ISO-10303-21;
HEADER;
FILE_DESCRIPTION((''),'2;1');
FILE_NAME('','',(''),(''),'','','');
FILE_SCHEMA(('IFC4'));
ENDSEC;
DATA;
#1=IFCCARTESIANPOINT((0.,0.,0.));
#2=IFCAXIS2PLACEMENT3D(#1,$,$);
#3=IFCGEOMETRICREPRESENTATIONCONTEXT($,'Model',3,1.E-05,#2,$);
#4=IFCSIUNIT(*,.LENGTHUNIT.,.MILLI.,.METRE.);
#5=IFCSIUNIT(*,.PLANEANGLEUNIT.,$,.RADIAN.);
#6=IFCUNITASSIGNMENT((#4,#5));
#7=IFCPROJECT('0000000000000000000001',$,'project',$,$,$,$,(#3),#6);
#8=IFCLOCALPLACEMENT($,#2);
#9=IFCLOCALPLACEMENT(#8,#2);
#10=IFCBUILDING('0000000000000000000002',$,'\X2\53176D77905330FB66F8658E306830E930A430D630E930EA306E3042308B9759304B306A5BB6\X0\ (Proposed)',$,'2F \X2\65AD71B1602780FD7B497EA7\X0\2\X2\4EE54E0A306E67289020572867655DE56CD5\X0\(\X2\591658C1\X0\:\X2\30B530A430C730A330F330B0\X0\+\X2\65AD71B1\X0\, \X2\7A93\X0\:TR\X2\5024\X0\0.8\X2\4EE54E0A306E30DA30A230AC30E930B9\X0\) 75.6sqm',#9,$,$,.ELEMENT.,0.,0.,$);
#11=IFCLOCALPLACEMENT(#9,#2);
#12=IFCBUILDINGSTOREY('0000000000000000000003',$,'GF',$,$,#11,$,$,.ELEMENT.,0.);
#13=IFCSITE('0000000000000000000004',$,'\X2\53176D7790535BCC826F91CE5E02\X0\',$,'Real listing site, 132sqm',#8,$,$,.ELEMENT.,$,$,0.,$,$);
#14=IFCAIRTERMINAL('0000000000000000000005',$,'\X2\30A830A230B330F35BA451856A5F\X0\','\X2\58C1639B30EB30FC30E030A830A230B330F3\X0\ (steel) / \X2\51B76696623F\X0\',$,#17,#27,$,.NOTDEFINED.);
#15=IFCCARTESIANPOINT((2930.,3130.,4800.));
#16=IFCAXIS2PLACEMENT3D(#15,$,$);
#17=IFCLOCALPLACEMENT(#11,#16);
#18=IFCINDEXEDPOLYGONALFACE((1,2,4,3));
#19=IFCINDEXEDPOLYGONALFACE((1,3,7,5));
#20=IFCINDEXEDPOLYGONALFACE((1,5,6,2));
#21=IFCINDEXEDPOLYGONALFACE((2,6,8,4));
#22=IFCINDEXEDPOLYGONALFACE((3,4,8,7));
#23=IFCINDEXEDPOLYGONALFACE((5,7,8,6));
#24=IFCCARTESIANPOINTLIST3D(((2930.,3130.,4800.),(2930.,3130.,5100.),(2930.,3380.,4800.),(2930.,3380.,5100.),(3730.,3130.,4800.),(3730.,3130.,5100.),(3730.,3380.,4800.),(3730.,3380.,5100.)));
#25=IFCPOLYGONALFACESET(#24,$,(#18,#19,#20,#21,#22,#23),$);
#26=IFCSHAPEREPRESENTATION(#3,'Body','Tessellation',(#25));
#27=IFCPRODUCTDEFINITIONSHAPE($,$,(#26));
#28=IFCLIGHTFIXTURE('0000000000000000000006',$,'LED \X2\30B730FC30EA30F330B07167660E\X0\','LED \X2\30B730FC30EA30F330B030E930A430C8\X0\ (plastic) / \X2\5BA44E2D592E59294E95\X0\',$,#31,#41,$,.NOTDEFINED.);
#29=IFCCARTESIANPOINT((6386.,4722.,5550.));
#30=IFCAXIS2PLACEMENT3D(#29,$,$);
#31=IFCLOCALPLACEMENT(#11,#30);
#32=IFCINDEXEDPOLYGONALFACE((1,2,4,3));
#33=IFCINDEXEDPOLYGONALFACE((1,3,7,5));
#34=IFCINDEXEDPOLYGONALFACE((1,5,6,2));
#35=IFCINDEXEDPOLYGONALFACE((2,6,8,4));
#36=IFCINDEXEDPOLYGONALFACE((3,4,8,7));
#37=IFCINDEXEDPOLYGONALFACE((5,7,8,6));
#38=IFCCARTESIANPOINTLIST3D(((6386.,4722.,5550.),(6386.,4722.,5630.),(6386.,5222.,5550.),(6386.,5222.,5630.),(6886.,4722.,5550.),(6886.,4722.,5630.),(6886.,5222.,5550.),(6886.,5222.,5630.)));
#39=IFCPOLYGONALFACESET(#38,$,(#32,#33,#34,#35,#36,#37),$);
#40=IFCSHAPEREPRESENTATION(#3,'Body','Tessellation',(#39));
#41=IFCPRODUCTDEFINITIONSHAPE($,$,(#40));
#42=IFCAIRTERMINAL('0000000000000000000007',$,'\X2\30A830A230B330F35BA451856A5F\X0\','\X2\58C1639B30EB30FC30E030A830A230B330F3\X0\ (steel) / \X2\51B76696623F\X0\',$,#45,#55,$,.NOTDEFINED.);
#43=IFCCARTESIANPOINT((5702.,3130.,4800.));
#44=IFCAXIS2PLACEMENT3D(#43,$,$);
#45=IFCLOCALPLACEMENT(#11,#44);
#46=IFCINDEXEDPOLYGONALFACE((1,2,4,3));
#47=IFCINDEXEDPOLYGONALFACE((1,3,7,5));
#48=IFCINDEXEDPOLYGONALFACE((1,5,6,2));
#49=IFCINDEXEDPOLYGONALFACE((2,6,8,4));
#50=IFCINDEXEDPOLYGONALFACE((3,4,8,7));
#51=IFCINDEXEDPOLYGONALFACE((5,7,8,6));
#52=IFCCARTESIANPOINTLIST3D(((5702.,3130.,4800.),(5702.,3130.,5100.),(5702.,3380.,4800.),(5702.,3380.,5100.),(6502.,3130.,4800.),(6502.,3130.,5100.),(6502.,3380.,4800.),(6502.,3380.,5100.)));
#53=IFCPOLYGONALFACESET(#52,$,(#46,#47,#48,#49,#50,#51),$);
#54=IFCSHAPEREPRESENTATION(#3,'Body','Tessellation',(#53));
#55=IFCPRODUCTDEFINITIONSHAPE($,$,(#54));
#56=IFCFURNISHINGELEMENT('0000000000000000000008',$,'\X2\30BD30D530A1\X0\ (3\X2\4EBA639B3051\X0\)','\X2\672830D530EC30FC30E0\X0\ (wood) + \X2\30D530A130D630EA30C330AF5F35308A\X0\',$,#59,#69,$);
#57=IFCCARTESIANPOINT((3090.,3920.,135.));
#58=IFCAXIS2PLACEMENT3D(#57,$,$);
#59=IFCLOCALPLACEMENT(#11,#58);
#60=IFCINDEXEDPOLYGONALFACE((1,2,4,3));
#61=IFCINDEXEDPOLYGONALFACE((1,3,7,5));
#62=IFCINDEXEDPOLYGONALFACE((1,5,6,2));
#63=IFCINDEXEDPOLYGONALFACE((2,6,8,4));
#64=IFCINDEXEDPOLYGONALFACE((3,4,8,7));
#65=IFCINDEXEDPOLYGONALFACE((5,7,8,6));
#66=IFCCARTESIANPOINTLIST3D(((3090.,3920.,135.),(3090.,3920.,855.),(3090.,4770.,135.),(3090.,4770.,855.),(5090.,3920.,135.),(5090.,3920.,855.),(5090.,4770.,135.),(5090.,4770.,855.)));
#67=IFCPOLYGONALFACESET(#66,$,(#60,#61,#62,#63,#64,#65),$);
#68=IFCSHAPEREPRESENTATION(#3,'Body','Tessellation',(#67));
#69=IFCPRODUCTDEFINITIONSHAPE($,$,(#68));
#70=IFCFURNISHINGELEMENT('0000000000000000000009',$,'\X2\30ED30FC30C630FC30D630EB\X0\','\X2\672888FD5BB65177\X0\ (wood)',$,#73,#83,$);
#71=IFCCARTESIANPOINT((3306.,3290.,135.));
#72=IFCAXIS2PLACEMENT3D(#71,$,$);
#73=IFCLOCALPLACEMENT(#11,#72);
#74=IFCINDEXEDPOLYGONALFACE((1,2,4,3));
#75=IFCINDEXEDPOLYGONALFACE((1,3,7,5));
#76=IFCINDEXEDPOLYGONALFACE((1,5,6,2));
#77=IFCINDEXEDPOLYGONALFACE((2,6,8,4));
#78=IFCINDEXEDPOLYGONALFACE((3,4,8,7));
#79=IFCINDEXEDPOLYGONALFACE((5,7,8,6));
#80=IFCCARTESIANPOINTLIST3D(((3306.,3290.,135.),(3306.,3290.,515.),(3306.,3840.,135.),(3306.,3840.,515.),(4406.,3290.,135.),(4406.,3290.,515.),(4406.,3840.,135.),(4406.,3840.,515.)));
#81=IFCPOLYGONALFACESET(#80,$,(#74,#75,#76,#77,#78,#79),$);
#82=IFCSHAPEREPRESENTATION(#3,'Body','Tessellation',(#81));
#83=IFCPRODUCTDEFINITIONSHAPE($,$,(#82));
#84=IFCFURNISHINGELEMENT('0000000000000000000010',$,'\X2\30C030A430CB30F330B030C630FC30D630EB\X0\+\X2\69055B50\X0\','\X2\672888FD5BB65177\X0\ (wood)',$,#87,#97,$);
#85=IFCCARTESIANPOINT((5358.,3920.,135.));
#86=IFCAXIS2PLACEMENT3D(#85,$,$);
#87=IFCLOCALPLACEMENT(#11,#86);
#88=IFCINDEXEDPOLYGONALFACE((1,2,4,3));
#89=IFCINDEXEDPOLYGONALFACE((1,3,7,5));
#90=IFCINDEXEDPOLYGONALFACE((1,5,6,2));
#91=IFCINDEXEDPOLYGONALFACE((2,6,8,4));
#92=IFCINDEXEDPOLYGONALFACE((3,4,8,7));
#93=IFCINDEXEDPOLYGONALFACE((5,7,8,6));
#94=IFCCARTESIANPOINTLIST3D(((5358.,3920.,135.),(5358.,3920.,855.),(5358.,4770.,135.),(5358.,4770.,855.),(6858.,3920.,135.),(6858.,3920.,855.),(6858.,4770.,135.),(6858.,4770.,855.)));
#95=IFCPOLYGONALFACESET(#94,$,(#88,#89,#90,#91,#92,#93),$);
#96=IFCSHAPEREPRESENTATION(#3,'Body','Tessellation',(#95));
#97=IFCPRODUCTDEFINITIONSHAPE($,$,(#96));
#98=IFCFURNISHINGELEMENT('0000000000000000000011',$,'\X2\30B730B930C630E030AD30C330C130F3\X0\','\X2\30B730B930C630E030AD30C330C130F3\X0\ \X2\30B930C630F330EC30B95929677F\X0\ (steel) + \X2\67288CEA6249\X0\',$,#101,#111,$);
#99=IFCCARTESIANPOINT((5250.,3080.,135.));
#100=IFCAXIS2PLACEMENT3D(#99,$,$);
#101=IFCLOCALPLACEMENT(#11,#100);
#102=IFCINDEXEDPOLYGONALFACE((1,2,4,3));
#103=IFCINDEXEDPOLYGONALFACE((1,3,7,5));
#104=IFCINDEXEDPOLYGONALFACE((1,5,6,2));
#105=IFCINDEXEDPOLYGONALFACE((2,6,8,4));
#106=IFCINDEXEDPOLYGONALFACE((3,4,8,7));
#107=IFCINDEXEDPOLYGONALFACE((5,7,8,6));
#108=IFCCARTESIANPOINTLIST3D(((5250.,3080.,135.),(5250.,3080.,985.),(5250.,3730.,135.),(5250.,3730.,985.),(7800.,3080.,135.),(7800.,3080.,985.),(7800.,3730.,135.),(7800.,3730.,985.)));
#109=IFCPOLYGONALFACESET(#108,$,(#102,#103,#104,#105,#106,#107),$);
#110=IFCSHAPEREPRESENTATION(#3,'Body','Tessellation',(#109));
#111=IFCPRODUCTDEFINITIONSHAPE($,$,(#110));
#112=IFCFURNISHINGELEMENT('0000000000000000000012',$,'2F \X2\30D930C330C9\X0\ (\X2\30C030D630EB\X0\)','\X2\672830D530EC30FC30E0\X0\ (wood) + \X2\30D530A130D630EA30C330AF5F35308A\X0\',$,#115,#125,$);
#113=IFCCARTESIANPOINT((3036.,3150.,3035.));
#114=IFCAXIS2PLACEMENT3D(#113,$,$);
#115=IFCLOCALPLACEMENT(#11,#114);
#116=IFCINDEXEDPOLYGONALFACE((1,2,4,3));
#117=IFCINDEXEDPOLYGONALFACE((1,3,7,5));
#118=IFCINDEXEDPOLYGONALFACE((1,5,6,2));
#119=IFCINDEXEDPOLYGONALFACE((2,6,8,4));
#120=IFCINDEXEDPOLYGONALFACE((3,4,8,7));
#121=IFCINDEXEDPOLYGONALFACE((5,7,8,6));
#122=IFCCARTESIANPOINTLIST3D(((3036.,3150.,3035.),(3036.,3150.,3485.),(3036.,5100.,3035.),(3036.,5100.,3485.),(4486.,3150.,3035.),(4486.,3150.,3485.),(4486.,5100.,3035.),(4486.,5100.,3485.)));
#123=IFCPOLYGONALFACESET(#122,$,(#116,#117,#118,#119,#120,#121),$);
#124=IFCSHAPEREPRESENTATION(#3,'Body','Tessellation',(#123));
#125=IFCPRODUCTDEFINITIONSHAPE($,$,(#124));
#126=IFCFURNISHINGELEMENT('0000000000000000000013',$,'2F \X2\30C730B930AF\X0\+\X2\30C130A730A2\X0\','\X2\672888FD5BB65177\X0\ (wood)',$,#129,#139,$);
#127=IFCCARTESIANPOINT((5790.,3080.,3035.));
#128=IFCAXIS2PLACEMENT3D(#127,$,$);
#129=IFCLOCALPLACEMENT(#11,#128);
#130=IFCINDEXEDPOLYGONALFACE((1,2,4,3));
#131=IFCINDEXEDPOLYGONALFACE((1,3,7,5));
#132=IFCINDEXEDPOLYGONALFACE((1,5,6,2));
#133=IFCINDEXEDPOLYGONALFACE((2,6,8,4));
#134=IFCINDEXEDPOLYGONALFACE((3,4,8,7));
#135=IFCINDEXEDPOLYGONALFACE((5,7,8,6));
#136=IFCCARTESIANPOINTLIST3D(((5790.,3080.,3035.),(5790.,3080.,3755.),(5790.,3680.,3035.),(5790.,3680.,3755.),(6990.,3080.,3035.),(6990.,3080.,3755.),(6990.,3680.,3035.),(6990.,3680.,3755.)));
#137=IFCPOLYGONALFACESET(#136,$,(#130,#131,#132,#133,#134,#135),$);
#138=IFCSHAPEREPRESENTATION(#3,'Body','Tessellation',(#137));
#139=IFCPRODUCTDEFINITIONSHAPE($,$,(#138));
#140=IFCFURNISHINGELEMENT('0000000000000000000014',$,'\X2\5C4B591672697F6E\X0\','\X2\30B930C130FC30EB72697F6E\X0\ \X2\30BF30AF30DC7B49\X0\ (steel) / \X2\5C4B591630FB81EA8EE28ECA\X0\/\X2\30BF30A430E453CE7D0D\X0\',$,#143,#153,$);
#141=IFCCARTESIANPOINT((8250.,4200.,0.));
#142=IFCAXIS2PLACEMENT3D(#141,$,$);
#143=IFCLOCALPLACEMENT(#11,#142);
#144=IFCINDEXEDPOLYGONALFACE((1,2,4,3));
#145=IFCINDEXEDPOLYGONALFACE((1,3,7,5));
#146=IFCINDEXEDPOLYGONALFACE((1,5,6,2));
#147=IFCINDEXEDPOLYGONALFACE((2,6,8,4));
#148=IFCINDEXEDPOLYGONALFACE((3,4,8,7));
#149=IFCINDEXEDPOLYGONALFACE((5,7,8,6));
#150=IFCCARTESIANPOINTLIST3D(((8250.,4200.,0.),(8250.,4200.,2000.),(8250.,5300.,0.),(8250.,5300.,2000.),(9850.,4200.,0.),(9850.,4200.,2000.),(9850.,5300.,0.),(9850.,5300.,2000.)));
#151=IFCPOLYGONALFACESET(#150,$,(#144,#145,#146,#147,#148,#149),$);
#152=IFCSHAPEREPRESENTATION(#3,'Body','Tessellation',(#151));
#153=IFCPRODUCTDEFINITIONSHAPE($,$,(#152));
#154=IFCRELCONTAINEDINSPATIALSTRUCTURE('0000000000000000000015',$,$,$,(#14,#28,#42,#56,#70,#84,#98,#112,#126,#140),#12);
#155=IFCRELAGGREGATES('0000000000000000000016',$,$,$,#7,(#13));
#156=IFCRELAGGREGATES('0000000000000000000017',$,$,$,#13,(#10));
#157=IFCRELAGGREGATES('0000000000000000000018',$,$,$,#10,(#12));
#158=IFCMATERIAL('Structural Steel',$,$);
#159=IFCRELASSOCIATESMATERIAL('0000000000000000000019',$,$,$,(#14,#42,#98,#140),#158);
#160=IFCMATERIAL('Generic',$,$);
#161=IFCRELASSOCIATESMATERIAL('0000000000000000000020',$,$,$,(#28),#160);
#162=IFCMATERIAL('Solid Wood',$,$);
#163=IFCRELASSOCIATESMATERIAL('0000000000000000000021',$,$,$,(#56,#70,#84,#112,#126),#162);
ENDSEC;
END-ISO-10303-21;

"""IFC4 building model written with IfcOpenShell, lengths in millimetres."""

from ifc_helpers import new_model, si_unit, frame, frame_2d, origin, place, context, project, spatial, rectangle, extrude, material, element, save


model = new_model("IFC4")

# Units and contexts
model_context = context("Model", 3, precision=1e-05, world=origin())
ifc_project = project(units=[si_unit("LENGTHUNIT", "METRE", prefix="MILLI"), si_unit("PLANEANGLEUNIT", "RADIAN")], contexts=[model_context])

# Site, building, storey
site_placement = place(None, origin())
site = spatial("IfcSite", under=ifc_project, at=site_placement, Name="北海道富良野市", ObjectType="Real listing site, 132sqm", CompositionType="ELEMENT", RefElevation=0.0)
building_placement = place(site_placement, origin())
building = spatial("IfcBuilding", under=site, at=building_placement, Name="北海道・書斎とライブラリのある静かな家 (Proposed)", ObjectType="2F 断熱性能等级2以上の木造在来工法(外壁:サイディング+断熱, 窓:TR値0.8以上のペアガラス) 75.6sqm", CompositionType="ELEMENT", ElevationOfRefHeight=0.0, ElevationOfTerrain=0.0)
storey_placement = place(building_placement, origin())
storey = spatial("IfcBuildingStorey", under=building, at=storey_placement, Name="GF", CompositionType="ELEMENT", Elevation=0.0)

# Shared definitions
ifc_material_1 = material(Name="Solid Wood")

# Shared definitions
ifc_material_2 = material(Name="Generic")

# Shared definitions
ifc_material_3 = material(Name="Structural Steel")

# Air terminal
air_terminal_1_placement = place(storey_placement, frame((2930.0, 3130.0, 4800.0)))
element("IfcAirTerminal", 1, at=air_terminal_1_placement, inside=storey, material=ifc_material_3, Name="エアコン室内機", Description="壁掛ルームエアコン (steel) / 冷暖房", PredefinedType="NOTDEFINED", context=model_context, shape_type="SweptSolid", body=[
    extrude(rectangle(XDim=800.0, YDim=250.0, at=frame_2d((400.0, 125.0))), frame((2930.0, 3130.0, 4800.0)), (0.0, 0.0, 1.0), 300.0),
])

# Light fixture
light_fixture_placement = place(storey_placement, frame((6386.0, 4722.0, 5550.0)))
element("IfcLightFixture", 2, at=light_fixture_placement, inside=storey, material=ifc_material_2, Name="LED シーリング照明", Description="LED シーリングライト (plastic) / 室中央天井", PredefinedType="NOTDEFINED", context=model_context, shape_type="SweptSolid", body=[
    extrude(rectangle(XDim=500.0, YDim=500.0, at=frame_2d((250.0, 250.0))), frame((6386.0, 4722.0, 5550.0)), (0.0, 0.0, 1.0), 80.0),
])

# Air terminal
air_terminal_2_placement = place(storey_placement, frame((5702.0, 3130.0, 4800.0)))
element("IfcAirTerminal", 3, at=air_terminal_2_placement, inside=storey, material=ifc_material_3, Name="エアコン室内機", Description="壁掛ルームエアコン (steel) / 冷暖房", PredefinedType="NOTDEFINED", context=model_context, shape_type="SweptSolid", body=[
    extrude(rectangle(XDim=800.0, YDim=250.0, at=frame_2d((400.0, 125.0))), frame((5702.0, 3130.0, 4800.0)), (0.0, 0.0, 1.0), 300.0),
])

# Furnishing elements
furnishing_1_placement = place(storey_placement, frame((3090.0, 3920.0, 135.0)))
element("IfcFurnishingElement", 4, at=furnishing_1_placement, inside=storey, material=ifc_material_1, Name="ソファ (3人掛け)", Description="木フレーム (wood) + ファブリック張り", context=model_context, shape_type="SweptSolid", body=[
    extrude(rectangle(XDim=2000.0, YDim=850.0, at=frame_2d((1000.0, 425.0))), frame((3090.0, 3920.0, 135.0)), (0.0, 0.0, 1.0), 720.0),
])
furnishing_2_placement = place(storey_placement, frame((3306.0, 3290.0, 135.0)))
element("IfcFurnishingElement", 5, at=furnishing_2_placement, inside=storey, material=ifc_material_1, Name="ローテーブル", Description="木製家具 (wood)", context=model_context, shape_type="SweptSolid", body=[
    extrude(rectangle(XDim=1100.0, YDim=550.0, at=frame_2d((550.0, 275.0))), frame((3306.0, 3290.0, 135.0)), (0.0, 0.0, 1.0), 380.0),
])
furnishing_3_placement = place(storey_placement, frame((5358.0, 3920.0, 135.0)))
element("IfcFurnishingElement", 6, at=furnishing_3_placement, inside=storey, material=ifc_material_1, Name="ダイニングテーブル+椅子", Description="木製家具 (wood)", context=model_context, shape_type="SweptSolid", body=[
    extrude(rectangle(XDim=1500.0, YDim=850.0, at=frame_2d((750.0, 425.0))), frame((5358.0, 3920.0, 135.0)), (0.0, 0.0, 1.0), 720.0),
])
furnishing_4_placement = place(storey_placement, frame((5250.0, 3080.0, 135.0)))
element("IfcFurnishingElement", 7, at=furnishing_4_placement, inside=storey, material=ifc_material_3, Name="システムキッチン", Description="システムキッチン ステンレス天板 (steel) + 木質扉", context=model_context, shape_type="SweptSolid", body=[
    extrude(rectangle(XDim=2550.0, YDim=650.0, at=frame_2d((1275.0, 325.0))), frame((5250.0, 3080.0, 135.0)), (0.0, 0.0, 1.0), 850.0),
])
furnishing_5_placement = place(storey_placement, frame((3036.0, 3150.0, 3035.0)))
element("IfcFurnishingElement", 8, at=furnishing_5_placement, inside=storey, material=ifc_material_1, Name="2F ベッド (ダブル)", Description="木フレーム (wood) + ファブリック張り", context=model_context, shape_type="SweptSolid", body=[
    extrude(rectangle(XDim=1450.0, YDim=1950.0, at=frame_2d((725.0, 975.0))), frame((3036.0, 3150.0, 3035.0)), (0.0, 0.0, 1.0), 450.0),
])
furnishing_6_placement = place(storey_placement, frame((5790.0, 3080.0, 3035.0)))
element("IfcFurnishingElement", 9, at=furnishing_6_placement, inside=storey, material=ifc_material_1, Name="2F デスク+チェア", Description="木製家具 (wood)", context=model_context, shape_type="SweptSolid", body=[
    extrude(rectangle(XDim=1200.0, YDim=600.0, at=frame_2d((600.0, 300.0))), frame((5790.0, 3080.0, 3035.0)), (0.0, 0.0, 1.0), 720.0),
])
furnishing_7_placement = place(storey_placement, frame((8250.0, 4200.0, 0.0)))
element("IfcFurnishingElement", 10, at=furnishing_7_placement, inside=storey, material=ifc_material_3, Name="屋外物置", Description="スチール物置 タクボ等 (steel) / 屋外・自転車/タイヤ収納", context=model_context, shape_type="SweptSolid", body=[
    extrude(rectangle(XDim=1600.0, YDim=1100.0, at=frame_2d((800.0, 550.0))), frame((8250.0, 4200.0, 0.0)), (0.0, 0.0, 1.0), 2000.0),
])

save(model, "model.ifc")
